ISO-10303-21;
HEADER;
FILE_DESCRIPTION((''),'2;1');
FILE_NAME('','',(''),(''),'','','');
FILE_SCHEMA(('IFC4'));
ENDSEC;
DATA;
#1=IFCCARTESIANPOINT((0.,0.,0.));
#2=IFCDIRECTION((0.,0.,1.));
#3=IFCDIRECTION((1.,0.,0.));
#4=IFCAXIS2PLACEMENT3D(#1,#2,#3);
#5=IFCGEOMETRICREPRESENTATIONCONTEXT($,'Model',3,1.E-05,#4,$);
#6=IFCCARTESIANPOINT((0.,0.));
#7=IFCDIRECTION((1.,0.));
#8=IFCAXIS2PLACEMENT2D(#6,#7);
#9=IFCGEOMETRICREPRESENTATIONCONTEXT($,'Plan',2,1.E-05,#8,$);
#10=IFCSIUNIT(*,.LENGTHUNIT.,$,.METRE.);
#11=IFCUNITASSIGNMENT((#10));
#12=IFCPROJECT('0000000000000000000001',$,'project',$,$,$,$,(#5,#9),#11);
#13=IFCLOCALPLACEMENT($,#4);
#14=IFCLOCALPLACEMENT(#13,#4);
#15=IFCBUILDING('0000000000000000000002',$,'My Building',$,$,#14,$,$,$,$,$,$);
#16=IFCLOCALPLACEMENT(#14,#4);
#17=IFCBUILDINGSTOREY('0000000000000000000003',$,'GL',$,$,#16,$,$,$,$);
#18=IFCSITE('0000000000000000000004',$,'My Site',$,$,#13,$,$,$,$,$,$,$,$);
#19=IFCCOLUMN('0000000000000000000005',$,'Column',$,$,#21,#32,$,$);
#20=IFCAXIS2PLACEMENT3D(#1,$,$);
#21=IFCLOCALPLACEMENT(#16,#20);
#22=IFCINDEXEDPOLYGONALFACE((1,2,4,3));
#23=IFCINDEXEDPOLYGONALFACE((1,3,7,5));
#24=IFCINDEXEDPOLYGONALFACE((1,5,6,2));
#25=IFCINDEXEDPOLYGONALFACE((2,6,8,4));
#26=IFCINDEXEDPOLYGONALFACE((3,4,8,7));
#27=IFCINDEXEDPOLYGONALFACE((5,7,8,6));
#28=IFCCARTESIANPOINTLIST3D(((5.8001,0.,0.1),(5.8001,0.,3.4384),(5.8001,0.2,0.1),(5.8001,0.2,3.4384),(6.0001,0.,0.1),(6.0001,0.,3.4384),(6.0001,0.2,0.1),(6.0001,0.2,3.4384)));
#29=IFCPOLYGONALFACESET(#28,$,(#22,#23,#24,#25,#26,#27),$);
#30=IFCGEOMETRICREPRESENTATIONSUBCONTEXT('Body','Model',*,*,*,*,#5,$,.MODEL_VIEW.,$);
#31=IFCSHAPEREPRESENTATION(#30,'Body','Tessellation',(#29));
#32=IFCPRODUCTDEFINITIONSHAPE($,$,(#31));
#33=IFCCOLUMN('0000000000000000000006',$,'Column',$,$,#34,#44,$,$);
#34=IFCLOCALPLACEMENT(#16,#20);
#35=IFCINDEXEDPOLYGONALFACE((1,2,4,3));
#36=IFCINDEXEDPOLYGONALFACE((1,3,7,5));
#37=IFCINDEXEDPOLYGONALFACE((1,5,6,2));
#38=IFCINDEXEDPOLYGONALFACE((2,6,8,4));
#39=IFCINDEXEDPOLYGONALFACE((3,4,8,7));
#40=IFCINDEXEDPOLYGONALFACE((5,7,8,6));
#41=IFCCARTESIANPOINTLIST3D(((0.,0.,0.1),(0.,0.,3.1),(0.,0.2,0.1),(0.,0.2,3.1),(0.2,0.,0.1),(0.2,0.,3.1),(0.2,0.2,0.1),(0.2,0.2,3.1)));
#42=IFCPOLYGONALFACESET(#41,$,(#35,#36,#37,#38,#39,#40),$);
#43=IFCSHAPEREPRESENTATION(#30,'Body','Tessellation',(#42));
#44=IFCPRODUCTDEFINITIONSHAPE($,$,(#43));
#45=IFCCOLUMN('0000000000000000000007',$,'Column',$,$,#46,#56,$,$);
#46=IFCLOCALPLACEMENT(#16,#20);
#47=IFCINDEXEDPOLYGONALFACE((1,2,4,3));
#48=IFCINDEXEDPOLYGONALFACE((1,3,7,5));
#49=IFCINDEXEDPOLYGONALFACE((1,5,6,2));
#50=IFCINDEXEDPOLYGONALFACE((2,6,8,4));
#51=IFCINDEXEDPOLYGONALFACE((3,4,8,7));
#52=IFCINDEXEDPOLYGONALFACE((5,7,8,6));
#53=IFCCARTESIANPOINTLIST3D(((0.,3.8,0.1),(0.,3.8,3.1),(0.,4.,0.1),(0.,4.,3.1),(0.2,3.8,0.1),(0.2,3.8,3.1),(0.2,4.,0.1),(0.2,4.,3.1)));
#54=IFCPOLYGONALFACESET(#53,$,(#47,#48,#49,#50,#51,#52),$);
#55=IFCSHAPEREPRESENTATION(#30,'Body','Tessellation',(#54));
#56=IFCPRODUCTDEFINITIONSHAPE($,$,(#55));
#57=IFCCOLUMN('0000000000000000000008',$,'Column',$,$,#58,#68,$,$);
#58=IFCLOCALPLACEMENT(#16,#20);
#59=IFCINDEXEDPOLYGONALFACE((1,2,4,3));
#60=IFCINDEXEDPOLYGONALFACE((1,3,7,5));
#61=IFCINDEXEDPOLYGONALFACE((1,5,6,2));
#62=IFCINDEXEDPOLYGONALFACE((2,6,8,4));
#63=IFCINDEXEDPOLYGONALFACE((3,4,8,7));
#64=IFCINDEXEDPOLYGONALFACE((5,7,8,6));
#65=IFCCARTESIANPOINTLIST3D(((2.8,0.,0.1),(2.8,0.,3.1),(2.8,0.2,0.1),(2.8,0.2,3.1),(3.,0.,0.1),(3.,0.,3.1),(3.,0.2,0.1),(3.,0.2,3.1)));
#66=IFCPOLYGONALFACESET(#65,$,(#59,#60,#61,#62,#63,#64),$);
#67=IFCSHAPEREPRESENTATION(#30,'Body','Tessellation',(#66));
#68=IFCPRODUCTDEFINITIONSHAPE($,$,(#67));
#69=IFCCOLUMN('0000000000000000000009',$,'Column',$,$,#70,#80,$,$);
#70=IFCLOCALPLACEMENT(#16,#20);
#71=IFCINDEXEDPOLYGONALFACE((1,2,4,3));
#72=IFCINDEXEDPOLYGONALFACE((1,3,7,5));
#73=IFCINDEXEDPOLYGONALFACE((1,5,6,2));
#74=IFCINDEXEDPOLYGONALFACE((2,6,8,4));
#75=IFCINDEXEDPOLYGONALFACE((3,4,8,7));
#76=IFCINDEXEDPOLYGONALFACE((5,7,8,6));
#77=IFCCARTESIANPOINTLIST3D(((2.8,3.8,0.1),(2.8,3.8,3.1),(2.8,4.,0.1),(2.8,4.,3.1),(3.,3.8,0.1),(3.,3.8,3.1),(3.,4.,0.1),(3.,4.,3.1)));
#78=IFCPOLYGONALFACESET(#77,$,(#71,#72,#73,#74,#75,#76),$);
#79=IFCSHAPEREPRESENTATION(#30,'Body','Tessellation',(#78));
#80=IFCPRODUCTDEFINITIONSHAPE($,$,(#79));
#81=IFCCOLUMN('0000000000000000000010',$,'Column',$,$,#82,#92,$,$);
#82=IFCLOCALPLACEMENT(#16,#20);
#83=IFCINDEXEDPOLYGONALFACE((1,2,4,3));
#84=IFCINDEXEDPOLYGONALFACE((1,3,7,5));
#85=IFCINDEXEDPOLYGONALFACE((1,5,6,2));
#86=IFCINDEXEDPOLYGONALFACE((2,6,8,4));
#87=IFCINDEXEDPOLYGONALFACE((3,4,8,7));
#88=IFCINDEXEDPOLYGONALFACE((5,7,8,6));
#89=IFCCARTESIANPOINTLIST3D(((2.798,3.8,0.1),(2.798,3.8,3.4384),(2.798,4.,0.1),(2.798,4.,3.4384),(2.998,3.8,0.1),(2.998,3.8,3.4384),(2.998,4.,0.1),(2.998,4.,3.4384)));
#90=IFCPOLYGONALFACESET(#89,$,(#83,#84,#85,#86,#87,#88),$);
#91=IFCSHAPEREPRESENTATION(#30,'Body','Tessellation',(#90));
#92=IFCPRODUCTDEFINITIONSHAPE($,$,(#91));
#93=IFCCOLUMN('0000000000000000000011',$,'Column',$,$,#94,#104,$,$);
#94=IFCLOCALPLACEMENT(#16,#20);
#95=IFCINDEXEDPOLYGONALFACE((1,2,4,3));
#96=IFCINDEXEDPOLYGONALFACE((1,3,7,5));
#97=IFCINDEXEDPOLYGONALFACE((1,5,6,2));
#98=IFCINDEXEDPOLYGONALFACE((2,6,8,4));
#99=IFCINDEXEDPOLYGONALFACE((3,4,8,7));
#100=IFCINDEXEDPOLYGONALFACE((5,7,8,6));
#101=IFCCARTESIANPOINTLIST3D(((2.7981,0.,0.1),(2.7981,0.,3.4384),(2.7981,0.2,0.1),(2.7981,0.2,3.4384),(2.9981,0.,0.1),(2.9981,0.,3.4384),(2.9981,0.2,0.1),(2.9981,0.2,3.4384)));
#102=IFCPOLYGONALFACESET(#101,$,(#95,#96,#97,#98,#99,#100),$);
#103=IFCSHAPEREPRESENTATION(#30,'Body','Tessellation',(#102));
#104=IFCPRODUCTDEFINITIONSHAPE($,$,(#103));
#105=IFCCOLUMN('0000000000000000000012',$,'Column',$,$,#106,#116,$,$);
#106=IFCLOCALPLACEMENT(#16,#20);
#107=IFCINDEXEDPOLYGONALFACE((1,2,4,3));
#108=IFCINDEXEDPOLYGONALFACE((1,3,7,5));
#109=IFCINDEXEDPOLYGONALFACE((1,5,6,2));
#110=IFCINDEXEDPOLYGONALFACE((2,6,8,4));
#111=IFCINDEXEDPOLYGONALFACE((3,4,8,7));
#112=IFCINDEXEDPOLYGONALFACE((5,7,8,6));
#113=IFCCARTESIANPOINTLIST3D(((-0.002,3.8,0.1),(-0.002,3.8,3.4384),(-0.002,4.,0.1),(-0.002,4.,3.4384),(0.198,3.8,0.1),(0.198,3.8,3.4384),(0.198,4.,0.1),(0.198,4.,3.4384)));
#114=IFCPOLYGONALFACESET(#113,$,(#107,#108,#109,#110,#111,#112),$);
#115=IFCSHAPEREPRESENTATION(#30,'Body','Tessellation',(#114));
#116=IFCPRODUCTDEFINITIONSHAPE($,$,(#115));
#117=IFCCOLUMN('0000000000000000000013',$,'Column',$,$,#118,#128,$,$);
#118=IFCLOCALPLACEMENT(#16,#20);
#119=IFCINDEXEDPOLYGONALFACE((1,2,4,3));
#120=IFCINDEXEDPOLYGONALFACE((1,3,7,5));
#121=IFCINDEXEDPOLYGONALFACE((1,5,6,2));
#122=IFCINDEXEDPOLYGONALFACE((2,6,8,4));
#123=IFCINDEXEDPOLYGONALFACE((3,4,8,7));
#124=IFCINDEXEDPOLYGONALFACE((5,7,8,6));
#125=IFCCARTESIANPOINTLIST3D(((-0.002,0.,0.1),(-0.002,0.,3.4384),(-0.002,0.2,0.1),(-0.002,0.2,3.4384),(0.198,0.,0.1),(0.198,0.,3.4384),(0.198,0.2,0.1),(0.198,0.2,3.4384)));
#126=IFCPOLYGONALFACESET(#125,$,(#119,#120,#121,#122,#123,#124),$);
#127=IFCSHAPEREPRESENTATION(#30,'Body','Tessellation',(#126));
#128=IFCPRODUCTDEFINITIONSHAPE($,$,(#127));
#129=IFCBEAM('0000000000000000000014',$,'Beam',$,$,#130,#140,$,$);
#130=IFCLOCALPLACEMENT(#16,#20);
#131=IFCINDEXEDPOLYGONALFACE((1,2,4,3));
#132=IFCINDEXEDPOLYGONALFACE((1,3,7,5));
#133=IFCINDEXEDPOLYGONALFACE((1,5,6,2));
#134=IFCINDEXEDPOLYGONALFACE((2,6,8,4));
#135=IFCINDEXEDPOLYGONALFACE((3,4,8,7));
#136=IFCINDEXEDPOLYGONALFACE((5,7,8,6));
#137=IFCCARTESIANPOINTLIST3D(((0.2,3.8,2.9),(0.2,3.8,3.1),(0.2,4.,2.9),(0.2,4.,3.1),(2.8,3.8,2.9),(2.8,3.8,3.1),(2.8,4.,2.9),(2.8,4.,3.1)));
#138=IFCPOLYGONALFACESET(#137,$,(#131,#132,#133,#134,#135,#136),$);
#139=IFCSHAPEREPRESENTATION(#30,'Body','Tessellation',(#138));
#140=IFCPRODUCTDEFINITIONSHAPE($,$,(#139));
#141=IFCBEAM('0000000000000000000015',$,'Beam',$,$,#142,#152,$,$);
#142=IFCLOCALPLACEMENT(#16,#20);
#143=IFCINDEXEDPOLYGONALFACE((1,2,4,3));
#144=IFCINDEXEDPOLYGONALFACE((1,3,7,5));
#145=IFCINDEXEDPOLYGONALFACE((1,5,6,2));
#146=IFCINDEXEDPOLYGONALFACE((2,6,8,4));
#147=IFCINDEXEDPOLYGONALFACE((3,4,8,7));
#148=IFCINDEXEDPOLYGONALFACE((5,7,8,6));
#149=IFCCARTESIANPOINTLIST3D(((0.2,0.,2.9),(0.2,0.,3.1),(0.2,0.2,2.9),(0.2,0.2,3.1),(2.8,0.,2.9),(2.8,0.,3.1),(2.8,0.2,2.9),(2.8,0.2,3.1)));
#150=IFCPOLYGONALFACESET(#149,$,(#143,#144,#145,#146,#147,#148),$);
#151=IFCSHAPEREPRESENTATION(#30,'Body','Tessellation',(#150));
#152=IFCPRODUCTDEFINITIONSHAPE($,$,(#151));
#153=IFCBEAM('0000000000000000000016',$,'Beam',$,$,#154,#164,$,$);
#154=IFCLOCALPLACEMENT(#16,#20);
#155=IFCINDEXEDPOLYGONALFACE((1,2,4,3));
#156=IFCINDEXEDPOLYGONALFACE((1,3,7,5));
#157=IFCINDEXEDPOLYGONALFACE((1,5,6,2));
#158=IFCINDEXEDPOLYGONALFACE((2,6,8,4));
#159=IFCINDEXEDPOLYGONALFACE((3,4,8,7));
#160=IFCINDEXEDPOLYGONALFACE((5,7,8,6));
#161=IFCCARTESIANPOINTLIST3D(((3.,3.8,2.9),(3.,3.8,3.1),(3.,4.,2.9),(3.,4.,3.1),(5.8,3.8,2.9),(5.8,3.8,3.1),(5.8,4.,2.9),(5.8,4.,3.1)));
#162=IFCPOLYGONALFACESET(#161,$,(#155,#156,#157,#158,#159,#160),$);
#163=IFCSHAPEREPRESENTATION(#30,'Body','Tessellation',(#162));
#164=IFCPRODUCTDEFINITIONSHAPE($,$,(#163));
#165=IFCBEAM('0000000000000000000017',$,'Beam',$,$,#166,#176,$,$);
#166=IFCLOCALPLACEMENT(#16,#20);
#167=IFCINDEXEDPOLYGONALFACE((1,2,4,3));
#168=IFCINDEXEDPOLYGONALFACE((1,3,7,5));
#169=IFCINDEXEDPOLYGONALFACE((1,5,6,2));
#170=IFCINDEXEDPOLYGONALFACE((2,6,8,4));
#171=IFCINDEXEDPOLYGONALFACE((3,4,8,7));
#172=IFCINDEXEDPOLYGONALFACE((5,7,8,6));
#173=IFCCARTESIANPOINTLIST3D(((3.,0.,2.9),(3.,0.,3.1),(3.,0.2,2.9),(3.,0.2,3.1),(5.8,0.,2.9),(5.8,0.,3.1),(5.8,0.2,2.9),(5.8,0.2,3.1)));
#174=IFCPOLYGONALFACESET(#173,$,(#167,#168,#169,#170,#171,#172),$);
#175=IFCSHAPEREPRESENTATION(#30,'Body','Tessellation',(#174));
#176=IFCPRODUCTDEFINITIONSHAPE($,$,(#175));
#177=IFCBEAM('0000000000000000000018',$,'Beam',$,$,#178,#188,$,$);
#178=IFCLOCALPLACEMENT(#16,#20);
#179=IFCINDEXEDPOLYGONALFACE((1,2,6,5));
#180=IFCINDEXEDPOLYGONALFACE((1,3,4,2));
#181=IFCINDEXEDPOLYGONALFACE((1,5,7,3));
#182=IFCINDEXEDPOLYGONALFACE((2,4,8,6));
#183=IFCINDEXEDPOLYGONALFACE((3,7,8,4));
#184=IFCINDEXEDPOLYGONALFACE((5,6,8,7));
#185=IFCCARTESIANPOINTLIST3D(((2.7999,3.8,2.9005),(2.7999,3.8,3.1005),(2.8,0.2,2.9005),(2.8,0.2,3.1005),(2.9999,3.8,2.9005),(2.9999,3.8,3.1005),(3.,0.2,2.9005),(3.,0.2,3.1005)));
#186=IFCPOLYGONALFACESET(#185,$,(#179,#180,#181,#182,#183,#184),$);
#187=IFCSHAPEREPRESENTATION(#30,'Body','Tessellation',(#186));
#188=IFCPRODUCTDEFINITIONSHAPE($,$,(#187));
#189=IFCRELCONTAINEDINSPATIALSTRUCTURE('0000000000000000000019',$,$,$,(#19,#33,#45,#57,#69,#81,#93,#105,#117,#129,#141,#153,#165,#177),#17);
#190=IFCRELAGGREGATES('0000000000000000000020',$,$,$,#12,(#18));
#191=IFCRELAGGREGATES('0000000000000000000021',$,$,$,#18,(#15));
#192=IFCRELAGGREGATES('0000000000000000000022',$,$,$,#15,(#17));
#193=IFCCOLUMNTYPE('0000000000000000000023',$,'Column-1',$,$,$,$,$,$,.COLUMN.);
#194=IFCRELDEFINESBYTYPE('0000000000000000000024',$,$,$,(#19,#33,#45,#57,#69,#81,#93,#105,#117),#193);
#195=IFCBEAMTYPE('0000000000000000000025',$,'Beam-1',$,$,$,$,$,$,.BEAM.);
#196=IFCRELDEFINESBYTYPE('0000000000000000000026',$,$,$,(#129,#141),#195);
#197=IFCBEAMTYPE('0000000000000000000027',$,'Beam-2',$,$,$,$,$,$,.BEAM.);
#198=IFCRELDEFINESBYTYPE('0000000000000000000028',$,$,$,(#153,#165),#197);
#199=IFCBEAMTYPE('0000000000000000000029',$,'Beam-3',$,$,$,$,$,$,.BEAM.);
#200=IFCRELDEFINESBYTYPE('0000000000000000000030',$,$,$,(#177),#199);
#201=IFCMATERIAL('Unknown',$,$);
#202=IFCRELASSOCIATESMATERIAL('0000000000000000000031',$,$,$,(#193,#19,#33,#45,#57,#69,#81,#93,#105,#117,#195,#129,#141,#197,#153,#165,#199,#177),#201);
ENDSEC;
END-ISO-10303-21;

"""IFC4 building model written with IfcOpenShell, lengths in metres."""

from ifc_helpers import new_model, si_unit, frame, origin_with_axes, origin_2d_with_axis, place, context, subcontext, project, spatial, rectangle, extrude, material, material_profile, profile_set, profile_usage, type_object, element, save


model = new_model("IFC4")

# Units and contexts
model_context = context("Model", 3, precision=1e-05, world=origin_with_axes())
plan_context = context("Plan", 2, precision=1e-05, world=origin_2d_with_axis())
body_context = subcontext(model_context, "Body", "Model", "MODEL_VIEW")
ifc_project = project(units=[si_unit("LENGTHUNIT", "METRE")], contexts=[model_context, plan_context])

# Site, building, storey
site_placement = place(None, origin_with_axes())
site = spatial("IfcSite", under=ifc_project, at=site_placement, Name="My Site")
building_placement = place(site_placement, origin_with_axes())
building = spatial("IfcBuilding", under=site, at=building_placement, Name="My Building")
storey_placement = place(building_placement, origin_with_axes())
storey = spatial("IfcBuildingStorey", under=building, at=storey_placement, Name="GL")

# Columns
ifc_material = material(Name="Unknown")
ifc_material_profile_1 = material_profile(ifc_material, rectangle(XDim=0.2, YDim=0.2))
ifc_profile_set_1 = profile_set([ifc_material_profile_1])
column_type_1 = type_object("IfcColumnType", Name="Column-1", PredefinedType="COLUMN", material=ifc_profile_set_1)
ifc_profile_usage_1 = profile_usage(ifc_profile_set_1, cardinal=5)
column_1_placement = place(storey_placement, frame((5.9001, 0.1, 0.1), z_axis=(0.0, 0.0, 1.0), x_axis=(1.0, 0.0, 0.0)))
element("IfcColumn", 1, at=column_1_placement, inside=storey, type_object=column_type_1, material=ifc_profile_usage_1, Name="Column", context=body_context, shape_type="SweptSolid", body=[
    extrude(rectangle(XDim=0.2, YDim=0.2), origin_with_axes(), (0.0, 0.0, 1.0), 3.3384),
])
ifc_profile_usage_2 = profile_usage(ifc_profile_set_1, cardinal=5)
column_2_placement = place(storey_placement, frame((0.1, 0.1, 3.1), z_axis=(0.0, 0.0, -1.0), x_axis=(-1.0, 0.0, 0.0)))
element("IfcColumn", 2, at=column_2_placement, inside=storey, type_object=column_type_1, material=ifc_profile_usage_2, Name="Column", context=body_context, shape_type="SweptSolid", body=[
    extrude(rectangle(XDim=0.2, YDim=0.2), origin_with_axes(), (0.0, 0.0, 1.0), 3.0),
])
ifc_profile_usage_3 = profile_usage(ifc_profile_set_1, cardinal=5)
column_3_placement = place(storey_placement, frame((0.1, 3.9, 3.1), z_axis=(0.0, 0.0, -1.0), x_axis=(-1.0, 0.0, 0.0)))
element("IfcColumn", 3, at=column_3_placement, inside=storey, type_object=column_type_1, material=ifc_profile_usage_3, Name="Column", context=body_context, shape_type="SweptSolid", body=[
    extrude(rectangle(XDim=0.2, YDim=0.2), origin_with_axes(), (0.0, 0.0, 1.0), 3.0),
])
ifc_profile_usage_4 = profile_usage(ifc_profile_set_1, cardinal=5)
column_4_placement = place(storey_placement, frame((2.9, 0.1, 3.1), z_axis=(0.0, 0.0, -1.0), x_axis=(-1.0, 0.0, 0.0)))
element("IfcColumn", 4, at=column_4_placement, inside=storey, type_object=column_type_1, material=ifc_profile_usage_4, Name="Column", context=body_context, shape_type="SweptSolid", body=[
    extrude(rectangle(XDim=0.2, YDim=0.2), origin_with_axes(), (0.0, 0.0, 1.0), 3.0),
])
ifc_profile_usage_5 = profile_usage(ifc_profile_set_1, cardinal=5)
column_5_placement = place(storey_placement, frame((2.9, 3.9, 3.1), z_axis=(0.0, 0.0, -1.0), x_axis=(-1.0, 0.0, 0.0)))
element("IfcColumn", 5, at=column_5_placement, inside=storey, type_object=column_type_1, material=ifc_profile_usage_5, Name="Column", context=body_context, shape_type="SweptSolid", body=[
    extrude(rectangle(XDim=0.2, YDim=0.2), origin_with_axes(), (0.0, 0.0, 1.0), 3.0),
])
ifc_profile_usage_6 = profile_usage(ifc_profile_set_1, cardinal=5)
column_6_placement = place(storey_placement, frame((2.898, 3.9, 0.1), z_axis=(0.0, 0.0, 1.0), x_axis=(1.0, 0.0, 0.0)))
element("IfcColumn", 6, at=column_6_placement, inside=storey, type_object=column_type_1, material=ifc_profile_usage_6, Name="Column", context=body_context, shape_type="SweptSolid", body=[
    extrude(rectangle(XDim=0.2, YDim=0.2), origin_with_axes(), (0.0, 0.0, 1.0), 3.3385),
])
ifc_profile_usage_7 = profile_usage(ifc_profile_set_1, cardinal=5)
column_7_placement = place(storey_placement, frame((2.8981, 0.1, 0.1), z_axis=(0.0, 0.0, 1.0), x_axis=(1.0, 0.0, 0.0)))
element("IfcColumn", 7, at=column_7_placement, inside=storey, type_object=column_type_1, material=ifc_profile_usage_7, Name="Column", context=body_context, shape_type="SweptSolid", body=[
    extrude(rectangle(XDim=0.2, YDim=0.2), origin_with_axes(), (0.0, 0.0, 1.0), 3.3384),
])
ifc_profile_usage_8 = profile_usage(ifc_profile_set_1, cardinal=5)
column_8_placement = place(storey_placement, frame((0.098, 3.9, 0.1), z_axis=(0.0, 0.0, 1.0), x_axis=(1.0, 0.0, 0.0)))
element("IfcColumn", 8, at=column_8_placement, inside=storey, type_object=column_type_1, material=ifc_profile_usage_8, Name="Column", context=body_context, shape_type="SweptSolid", body=[
    extrude(rectangle(XDim=0.2, YDim=0.2), origin_with_axes(), (0.0, 0.0, 1.0), 3.3385),
])
ifc_profile_usage_9 = profile_usage(ifc_profile_set_1, cardinal=5)
column_9_placement = place(storey_placement, frame((0.098, 0.1, 0.1), z_axis=(0.0, 0.0, 1.0), x_axis=(1.0, 0.0, 0.0)))
element("IfcColumn", 9, at=column_9_placement, inside=storey, type_object=column_type_1, material=ifc_profile_usage_9, Name="Column", context=body_context, shape_type="SweptSolid", body=[
    extrude(rectangle(XDim=0.2, YDim=0.2), origin_with_axes(), (0.0, 0.0, 1.0), 3.3384),
])

# Beams
ifc_material_profile_2 = material_profile(ifc_material, rectangle(XDim=0.2, YDim=0.2))
ifc_profile_set_2 = profile_set([ifc_material_profile_2])
ifc_profile_usage_10 = profile_usage(ifc_profile_set_2, cardinal=5)
beam_type_1 = type_object("IfcBeamType", Name="Beam-1", PredefinedType="BEAM", material=ifc_profile_set_2)
beam_1_placement = place(storey_placement, frame((0.2, 3.9, 3.0), z_axis=(1.0, 0.0, 0.0), x_axis=(0.0, 1.0, 0.0)))
element("IfcBeam", 10, at=beam_1_placement, inside=storey, type_object=beam_type_1, material=ifc_profile_usage_10, Name="Beam", context=body_context, shape_type="SweptSolid", body=[
    extrude(rectangle(XDim=0.2, YDim=0.2), origin_with_axes(), (0.0, 0.0, 1.0), 2.6),
])
ifc_profile_usage_11 = profile_usage(ifc_profile_set_2, cardinal=5)
beam_2_placement = place(storey_placement, frame((0.2, 0.1, 3.0), z_axis=(1.0, 0.0, 0.0), x_axis=(0.0, 1.0, 0.0)))
element("IfcBeam", 11, at=beam_2_placement, inside=storey, type_object=beam_type_1, material=ifc_profile_usage_11, Name="Beam", context=body_context, shape_type="SweptSolid", body=[
    extrude(rectangle(XDim=0.2, YDim=0.2), origin_with_axes(), (0.0, 0.0, 1.0), 2.6),
])
ifc_material_profile_3 = material_profile(ifc_material, rectangle(XDim=0.2, YDim=0.2))
ifc_profile_set_3 = profile_set([ifc_material_profile_3])
ifc_profile_usage_12 = profile_usage(ifc_profile_set_3, cardinal=5)
beam_type_2 = type_object("IfcBeamType", Name="Beam-2", PredefinedType="BEAM", material=ifc_profile_set_3)
beam_3_placement = place(storey_placement, frame((3.0, 3.9, 3.0), z_axis=(1.0, 0.0, -0.00001), x_axis=(0.0, 1.0, 0.0)))
element("IfcBeam", 12, at=beam_3_placement, inside=storey, type_object=beam_type_2, material=ifc_profile_usage_12, Name="Beam", context=body_context, shape_type="SweptSolid", body=[
    extrude(rectangle(XDim=0.2, YDim=0.2), origin_with_axes(), (0.0, 0.0, 1.0), 2.8),
])
ifc_profile_usage_13 = profile_usage(ifc_profile_set_3, cardinal=5)
beam_4_placement = place(storey_placement, frame((3.0, 0.1, 3.0), z_axis=(1.0, 0.0, -0.00001), x_axis=(0.0, 1.0, 0.0)))
element("IfcBeam", 13, at=beam_4_placement, inside=storey, type_object=beam_type_2, material=ifc_profile_usage_13, Name="Beam", context=body_context, shape_type="SweptSolid", body=[
    extrude(rectangle(XDim=0.2, YDim=0.2), origin_with_axes(), (0.0, 0.0, 1.0), 2.8),
])
ifc_material_profile_4 = material_profile(ifc_material, rectangle(XDim=0.2, YDim=0.2))
ifc_profile_set_4 = profile_set([ifc_material_profile_4])
ifc_profile_usage_14 = profile_usage(ifc_profile_set_4, cardinal=5)
beam_type_3 = type_object("IfcBeamType", Name="Beam-3", PredefinedType="BEAM", material=ifc_profile_set_4)
beam_5_placement = place(storey_placement, frame((2.9, 0.2, 3.0005), z_axis=(-0.000043, 1.0, 0.0), x_axis=(-1.0, -0.000043, 0.0)))
element("IfcBeam", 14, at=beam_5_placement, inside=storey, type_object=beam_type_3, material=ifc_profile_usage_14, Name="Beam", context=body_context, shape_type="SweptSolid", body=[
    extrude(rectangle(XDim=0.2, YDim=0.2), origin_with_axes(), (0.0, 0.0, 1.0), 3.6),
])

save(model, "model.ifc")
